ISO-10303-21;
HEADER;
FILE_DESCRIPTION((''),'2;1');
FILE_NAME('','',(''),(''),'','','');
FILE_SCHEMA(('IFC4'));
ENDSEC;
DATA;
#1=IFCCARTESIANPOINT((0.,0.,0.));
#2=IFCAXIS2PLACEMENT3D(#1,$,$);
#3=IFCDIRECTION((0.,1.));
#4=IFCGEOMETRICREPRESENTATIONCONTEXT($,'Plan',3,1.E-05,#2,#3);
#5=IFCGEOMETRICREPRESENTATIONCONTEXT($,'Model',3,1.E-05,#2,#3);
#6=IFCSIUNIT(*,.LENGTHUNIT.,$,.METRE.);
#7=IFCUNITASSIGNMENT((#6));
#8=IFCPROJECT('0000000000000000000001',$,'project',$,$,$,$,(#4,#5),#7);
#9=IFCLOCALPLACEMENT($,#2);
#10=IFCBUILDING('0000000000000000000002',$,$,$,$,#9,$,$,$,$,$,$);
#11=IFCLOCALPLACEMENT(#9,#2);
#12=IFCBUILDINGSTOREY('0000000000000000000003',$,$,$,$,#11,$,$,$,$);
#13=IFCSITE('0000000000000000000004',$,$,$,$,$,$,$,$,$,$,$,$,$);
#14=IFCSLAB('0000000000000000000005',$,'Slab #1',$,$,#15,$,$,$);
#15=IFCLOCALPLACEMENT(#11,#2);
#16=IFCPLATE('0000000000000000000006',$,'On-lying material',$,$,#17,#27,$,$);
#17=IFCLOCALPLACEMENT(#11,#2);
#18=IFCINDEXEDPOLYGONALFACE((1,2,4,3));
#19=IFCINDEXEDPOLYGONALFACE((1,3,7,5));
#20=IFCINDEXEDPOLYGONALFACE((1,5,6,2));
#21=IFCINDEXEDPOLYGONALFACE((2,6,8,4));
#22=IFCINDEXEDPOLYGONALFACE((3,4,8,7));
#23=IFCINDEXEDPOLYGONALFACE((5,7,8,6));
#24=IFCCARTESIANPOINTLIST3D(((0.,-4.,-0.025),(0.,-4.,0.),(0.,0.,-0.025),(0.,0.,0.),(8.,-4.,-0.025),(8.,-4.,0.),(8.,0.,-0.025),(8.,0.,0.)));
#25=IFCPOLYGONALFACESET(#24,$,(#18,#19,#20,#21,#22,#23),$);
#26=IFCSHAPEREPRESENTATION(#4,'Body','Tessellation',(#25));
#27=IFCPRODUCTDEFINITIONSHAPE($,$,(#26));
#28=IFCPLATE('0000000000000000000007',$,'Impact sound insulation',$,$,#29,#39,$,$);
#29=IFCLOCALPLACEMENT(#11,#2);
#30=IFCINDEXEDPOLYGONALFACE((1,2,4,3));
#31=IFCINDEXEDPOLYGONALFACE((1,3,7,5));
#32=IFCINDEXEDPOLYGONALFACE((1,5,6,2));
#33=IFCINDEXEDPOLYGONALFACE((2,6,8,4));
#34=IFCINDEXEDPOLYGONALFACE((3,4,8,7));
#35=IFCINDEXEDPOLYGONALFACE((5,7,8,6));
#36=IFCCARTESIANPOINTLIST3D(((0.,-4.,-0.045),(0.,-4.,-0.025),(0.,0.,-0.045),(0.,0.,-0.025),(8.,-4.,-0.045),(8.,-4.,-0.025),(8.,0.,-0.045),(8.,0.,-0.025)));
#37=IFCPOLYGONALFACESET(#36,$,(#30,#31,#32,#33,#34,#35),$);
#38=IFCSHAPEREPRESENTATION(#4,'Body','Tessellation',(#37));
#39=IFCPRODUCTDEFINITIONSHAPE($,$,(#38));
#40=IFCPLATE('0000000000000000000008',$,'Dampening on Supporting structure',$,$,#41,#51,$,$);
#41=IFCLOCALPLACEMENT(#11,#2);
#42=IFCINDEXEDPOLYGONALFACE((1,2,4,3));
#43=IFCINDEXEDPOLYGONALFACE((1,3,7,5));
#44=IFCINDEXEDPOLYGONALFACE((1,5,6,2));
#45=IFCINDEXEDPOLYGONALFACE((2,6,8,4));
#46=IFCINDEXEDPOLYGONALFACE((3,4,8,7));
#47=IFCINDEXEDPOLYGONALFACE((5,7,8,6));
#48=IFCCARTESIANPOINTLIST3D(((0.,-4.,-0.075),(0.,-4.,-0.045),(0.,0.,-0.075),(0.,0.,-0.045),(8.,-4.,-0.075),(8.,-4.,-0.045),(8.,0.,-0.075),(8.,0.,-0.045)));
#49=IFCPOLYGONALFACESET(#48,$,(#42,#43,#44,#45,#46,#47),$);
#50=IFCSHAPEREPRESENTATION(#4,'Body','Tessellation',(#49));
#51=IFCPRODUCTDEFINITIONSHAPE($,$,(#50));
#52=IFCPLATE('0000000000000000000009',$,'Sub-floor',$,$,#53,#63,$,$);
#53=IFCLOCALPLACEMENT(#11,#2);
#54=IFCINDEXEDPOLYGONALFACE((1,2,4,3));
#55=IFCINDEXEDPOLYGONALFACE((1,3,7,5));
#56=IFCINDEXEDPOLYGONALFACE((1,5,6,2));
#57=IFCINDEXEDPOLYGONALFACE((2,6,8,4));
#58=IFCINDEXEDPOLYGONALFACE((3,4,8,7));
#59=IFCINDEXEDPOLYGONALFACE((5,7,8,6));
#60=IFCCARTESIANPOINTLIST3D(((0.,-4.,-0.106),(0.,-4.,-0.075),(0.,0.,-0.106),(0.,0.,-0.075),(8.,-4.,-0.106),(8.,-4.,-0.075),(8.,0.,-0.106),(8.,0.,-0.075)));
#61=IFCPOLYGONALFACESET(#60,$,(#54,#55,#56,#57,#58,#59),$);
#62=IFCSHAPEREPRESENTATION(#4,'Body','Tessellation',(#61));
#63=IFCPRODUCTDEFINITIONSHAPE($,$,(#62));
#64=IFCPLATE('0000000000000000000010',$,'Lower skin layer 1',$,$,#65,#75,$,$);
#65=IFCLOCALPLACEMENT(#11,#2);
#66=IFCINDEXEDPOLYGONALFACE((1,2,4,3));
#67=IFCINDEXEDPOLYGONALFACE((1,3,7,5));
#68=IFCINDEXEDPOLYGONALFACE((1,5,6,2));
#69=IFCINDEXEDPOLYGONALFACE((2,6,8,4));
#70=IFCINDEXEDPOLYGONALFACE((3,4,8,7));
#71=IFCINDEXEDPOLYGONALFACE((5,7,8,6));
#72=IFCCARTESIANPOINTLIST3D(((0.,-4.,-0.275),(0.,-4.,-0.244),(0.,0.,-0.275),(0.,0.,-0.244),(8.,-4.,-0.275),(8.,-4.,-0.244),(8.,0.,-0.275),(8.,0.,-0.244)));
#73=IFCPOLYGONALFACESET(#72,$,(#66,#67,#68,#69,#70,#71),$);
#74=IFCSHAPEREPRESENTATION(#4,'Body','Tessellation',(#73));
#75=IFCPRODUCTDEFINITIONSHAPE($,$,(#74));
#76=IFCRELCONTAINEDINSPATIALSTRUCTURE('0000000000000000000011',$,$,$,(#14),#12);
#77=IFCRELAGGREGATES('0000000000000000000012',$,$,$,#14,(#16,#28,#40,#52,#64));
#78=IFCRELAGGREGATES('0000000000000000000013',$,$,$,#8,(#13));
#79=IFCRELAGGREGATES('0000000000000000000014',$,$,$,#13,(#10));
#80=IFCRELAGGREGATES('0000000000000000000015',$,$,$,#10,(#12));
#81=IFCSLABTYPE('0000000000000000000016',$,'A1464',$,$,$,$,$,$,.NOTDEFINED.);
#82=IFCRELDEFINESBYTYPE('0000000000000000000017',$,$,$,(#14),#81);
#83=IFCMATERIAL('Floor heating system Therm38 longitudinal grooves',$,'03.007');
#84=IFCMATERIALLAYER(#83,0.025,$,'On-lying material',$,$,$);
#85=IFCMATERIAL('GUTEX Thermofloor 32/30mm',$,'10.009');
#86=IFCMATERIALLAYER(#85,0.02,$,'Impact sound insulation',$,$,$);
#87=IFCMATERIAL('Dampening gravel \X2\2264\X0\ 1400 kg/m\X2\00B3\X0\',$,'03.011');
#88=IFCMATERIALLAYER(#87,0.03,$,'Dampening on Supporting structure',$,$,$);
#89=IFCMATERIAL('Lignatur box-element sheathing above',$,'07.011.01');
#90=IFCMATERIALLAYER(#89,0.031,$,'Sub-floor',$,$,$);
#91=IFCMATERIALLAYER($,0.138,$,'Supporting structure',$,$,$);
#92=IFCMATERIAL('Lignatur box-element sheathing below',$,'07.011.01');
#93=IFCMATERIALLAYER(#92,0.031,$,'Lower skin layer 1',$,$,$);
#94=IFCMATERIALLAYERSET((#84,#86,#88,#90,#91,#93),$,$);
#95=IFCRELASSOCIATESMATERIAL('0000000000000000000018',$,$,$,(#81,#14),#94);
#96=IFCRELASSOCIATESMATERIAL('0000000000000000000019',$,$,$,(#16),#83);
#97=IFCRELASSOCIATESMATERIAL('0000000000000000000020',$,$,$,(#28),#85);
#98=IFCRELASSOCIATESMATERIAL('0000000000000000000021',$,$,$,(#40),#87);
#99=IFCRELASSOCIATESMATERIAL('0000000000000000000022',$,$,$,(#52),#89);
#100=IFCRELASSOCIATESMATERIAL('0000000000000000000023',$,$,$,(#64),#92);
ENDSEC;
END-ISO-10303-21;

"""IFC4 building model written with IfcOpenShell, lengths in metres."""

from ifc_helpers import new_model, si_unit, direction, frame, frame_2d, origin, origin_with_axes, place, context, project, spatial, rectangle, extrude, material, layer, layer_set, type_object, element, aggregate, save


model = new_model("IFC4")

# Units and contexts
plan_context = context("Plan", 3, precision=1e-05, world=origin(), true_north=direction((0.0, 1.0)))
model_context = context("Model", 3, precision=1e-05, world=origin(), true_north=direction((0.0, 1.0)))
ifc_project = project(units=[si_unit("LENGTHUNIT", "METRE")], contexts=[plan_context, model_context])

# Site, building, storey
site = spatial("IfcSite", under=ifc_project)
building_placement = place(None, origin())
building = spatial("IfcBuilding", under=site, at=building_placement)
storey_placement = place(building_placement, origin())
storey = spatial("IfcBuildingStorey", under=building, at=storey_placement)

# Slab, plates
ifc_material_1 = material(Name="Floor heating system Therm38 longitudinal grooves", Category="03.007")
ifc_layer_1 = layer(ifc_material_1, 0.025, Name="On-lying material")
ifc_material_2 = material(Name="GUTEX Thermofloor 32/30mm", Category="10.009")
ifc_layer_2 = layer(ifc_material_2, 0.02, Name="Impact sound insulation")
ifc_material_3 = material(Name="Dampening gravel ≤ 1400 kg/m³", Category="03.011")
ifc_layer_3 = layer(ifc_material_3, 0.03, Name="Dampening on Supporting structure")
ifc_material_4 = material(Name="Lignatur box-element sheathing above", Category="07.011.01")
ifc_layer_4 = layer(ifc_material_4, 0.031, Name="Sub-floor")
ifc_layer_5 = layer(None, 0.138, Name="Supporting structure")
ifc_material_5 = material(Name="Lignatur box-element sheathing below", Category="07.011.01")
ifc_layer_6 = layer(ifc_material_5, 0.031, Name="Lower skin layer 1")
ifc_layer_set = layer_set([ifc_layer_1, ifc_layer_2, ifc_layer_3, ifc_layer_4, ifc_layer_5, ifc_layer_6])
slab_type = type_object("IfcSlabType", Name="A1464", PredefinedType="NOTDEFINED", material=ifc_layer_set)
slab_placement = place(None, frame((0.0, 0.0, 0.0), z_axis=(0.0, 0.0, -1.0), x_axis=(1.0, 0.0, 0.0)))
slab = element("IfcSlab", 1, at=slab_placement, inside=storey, type_object=slab_type, material=ifc_layer_set, Name="Slab #1")
plate_1_placement = place(slab_placement, origin())
plate_1 = element("IfcPlate", 2, at=plate_1_placement, material=ifc_material_1, Name="On-lying material", context=plan_context, shape_type="SweptSolid", body=[
    extrude(rectangle(XDim=8.0, YDim=4.0, at=frame_2d((4.0, 2.0), x_axis=(1.0, 0.0))), origin_with_axes(), (0.0, 0.0, 1.0), 0.025),
])
plate_2_placement = place(slab_placement, origin())
plate_2 = element("IfcPlate", 3, at=plate_2_placement, material=ifc_material_2, Name="Impact sound insulation", context=plan_context, shape_type="SweptSolid", body=[
    extrude(rectangle(XDim=8.0, YDim=4.0, at=frame_2d((4.0, 2.0), x_axis=(1.0, 0.0))), frame((0.0, 0.0, 0.025), z_axis=(0.0, 0.0, 1.0), x_axis=(1.0, 0.0, 0.0)), (0.0, 0.0, 1.0), 0.02),
])
plate_3_placement = place(slab_placement, origin())
plate_3 = element("IfcPlate", 4, at=plate_3_placement, material=ifc_material_3, Name="Dampening on Supporting structure", context=plan_context, shape_type="SweptSolid", body=[
    extrude(rectangle(XDim=8.0, YDim=4.0, at=frame_2d((4.0, 2.0), x_axis=(1.0, 0.0))), frame((0.0, 0.0, 0.045), z_axis=(0.0, 0.0, 1.0), x_axis=(1.0, 0.0, 0.0)), (0.0, 0.0, 1.0), 0.03),
])
plate_4_placement = place(slab_placement, origin())
plate_4 = element("IfcPlate", 5, at=plate_4_placement, material=ifc_material_4, Name="Sub-floor", context=plan_context, shape_type="SweptSolid", body=[
    extrude(rectangle(XDim=8.0, YDim=4.0, at=frame_2d((4.0, 2.0), x_axis=(1.0, 0.0))), frame((0.0, 0.0, 0.075), z_axis=(0.0, 0.0, 1.0), x_axis=(1.0, 0.0, 0.0)), (0.0, 0.0, 1.0), 0.031),
])
plate_5_placement = place(slab_placement, origin())
plate_5 = element("IfcPlate", 6, at=plate_5_placement, material=ifc_material_5, Name="Lower skin layer 1", context=plan_context, shape_type="SweptSolid", body=[
    extrude(rectangle(XDim=8.0, YDim=4.0, at=frame_2d((4.0, 2.0), x_axis=(1.0, 0.0))), frame((0.0, 0.0, 0.244), z_axis=(0.0, 0.0, 1.0), x_axis=(1.0, 0.0, 0.0)), (0.0, 0.0, 1.0), 0.031),
])
aggregate(slab, [plate_1, plate_2, plate_3, plate_4, plate_5])

save(model, "model.ifc")
